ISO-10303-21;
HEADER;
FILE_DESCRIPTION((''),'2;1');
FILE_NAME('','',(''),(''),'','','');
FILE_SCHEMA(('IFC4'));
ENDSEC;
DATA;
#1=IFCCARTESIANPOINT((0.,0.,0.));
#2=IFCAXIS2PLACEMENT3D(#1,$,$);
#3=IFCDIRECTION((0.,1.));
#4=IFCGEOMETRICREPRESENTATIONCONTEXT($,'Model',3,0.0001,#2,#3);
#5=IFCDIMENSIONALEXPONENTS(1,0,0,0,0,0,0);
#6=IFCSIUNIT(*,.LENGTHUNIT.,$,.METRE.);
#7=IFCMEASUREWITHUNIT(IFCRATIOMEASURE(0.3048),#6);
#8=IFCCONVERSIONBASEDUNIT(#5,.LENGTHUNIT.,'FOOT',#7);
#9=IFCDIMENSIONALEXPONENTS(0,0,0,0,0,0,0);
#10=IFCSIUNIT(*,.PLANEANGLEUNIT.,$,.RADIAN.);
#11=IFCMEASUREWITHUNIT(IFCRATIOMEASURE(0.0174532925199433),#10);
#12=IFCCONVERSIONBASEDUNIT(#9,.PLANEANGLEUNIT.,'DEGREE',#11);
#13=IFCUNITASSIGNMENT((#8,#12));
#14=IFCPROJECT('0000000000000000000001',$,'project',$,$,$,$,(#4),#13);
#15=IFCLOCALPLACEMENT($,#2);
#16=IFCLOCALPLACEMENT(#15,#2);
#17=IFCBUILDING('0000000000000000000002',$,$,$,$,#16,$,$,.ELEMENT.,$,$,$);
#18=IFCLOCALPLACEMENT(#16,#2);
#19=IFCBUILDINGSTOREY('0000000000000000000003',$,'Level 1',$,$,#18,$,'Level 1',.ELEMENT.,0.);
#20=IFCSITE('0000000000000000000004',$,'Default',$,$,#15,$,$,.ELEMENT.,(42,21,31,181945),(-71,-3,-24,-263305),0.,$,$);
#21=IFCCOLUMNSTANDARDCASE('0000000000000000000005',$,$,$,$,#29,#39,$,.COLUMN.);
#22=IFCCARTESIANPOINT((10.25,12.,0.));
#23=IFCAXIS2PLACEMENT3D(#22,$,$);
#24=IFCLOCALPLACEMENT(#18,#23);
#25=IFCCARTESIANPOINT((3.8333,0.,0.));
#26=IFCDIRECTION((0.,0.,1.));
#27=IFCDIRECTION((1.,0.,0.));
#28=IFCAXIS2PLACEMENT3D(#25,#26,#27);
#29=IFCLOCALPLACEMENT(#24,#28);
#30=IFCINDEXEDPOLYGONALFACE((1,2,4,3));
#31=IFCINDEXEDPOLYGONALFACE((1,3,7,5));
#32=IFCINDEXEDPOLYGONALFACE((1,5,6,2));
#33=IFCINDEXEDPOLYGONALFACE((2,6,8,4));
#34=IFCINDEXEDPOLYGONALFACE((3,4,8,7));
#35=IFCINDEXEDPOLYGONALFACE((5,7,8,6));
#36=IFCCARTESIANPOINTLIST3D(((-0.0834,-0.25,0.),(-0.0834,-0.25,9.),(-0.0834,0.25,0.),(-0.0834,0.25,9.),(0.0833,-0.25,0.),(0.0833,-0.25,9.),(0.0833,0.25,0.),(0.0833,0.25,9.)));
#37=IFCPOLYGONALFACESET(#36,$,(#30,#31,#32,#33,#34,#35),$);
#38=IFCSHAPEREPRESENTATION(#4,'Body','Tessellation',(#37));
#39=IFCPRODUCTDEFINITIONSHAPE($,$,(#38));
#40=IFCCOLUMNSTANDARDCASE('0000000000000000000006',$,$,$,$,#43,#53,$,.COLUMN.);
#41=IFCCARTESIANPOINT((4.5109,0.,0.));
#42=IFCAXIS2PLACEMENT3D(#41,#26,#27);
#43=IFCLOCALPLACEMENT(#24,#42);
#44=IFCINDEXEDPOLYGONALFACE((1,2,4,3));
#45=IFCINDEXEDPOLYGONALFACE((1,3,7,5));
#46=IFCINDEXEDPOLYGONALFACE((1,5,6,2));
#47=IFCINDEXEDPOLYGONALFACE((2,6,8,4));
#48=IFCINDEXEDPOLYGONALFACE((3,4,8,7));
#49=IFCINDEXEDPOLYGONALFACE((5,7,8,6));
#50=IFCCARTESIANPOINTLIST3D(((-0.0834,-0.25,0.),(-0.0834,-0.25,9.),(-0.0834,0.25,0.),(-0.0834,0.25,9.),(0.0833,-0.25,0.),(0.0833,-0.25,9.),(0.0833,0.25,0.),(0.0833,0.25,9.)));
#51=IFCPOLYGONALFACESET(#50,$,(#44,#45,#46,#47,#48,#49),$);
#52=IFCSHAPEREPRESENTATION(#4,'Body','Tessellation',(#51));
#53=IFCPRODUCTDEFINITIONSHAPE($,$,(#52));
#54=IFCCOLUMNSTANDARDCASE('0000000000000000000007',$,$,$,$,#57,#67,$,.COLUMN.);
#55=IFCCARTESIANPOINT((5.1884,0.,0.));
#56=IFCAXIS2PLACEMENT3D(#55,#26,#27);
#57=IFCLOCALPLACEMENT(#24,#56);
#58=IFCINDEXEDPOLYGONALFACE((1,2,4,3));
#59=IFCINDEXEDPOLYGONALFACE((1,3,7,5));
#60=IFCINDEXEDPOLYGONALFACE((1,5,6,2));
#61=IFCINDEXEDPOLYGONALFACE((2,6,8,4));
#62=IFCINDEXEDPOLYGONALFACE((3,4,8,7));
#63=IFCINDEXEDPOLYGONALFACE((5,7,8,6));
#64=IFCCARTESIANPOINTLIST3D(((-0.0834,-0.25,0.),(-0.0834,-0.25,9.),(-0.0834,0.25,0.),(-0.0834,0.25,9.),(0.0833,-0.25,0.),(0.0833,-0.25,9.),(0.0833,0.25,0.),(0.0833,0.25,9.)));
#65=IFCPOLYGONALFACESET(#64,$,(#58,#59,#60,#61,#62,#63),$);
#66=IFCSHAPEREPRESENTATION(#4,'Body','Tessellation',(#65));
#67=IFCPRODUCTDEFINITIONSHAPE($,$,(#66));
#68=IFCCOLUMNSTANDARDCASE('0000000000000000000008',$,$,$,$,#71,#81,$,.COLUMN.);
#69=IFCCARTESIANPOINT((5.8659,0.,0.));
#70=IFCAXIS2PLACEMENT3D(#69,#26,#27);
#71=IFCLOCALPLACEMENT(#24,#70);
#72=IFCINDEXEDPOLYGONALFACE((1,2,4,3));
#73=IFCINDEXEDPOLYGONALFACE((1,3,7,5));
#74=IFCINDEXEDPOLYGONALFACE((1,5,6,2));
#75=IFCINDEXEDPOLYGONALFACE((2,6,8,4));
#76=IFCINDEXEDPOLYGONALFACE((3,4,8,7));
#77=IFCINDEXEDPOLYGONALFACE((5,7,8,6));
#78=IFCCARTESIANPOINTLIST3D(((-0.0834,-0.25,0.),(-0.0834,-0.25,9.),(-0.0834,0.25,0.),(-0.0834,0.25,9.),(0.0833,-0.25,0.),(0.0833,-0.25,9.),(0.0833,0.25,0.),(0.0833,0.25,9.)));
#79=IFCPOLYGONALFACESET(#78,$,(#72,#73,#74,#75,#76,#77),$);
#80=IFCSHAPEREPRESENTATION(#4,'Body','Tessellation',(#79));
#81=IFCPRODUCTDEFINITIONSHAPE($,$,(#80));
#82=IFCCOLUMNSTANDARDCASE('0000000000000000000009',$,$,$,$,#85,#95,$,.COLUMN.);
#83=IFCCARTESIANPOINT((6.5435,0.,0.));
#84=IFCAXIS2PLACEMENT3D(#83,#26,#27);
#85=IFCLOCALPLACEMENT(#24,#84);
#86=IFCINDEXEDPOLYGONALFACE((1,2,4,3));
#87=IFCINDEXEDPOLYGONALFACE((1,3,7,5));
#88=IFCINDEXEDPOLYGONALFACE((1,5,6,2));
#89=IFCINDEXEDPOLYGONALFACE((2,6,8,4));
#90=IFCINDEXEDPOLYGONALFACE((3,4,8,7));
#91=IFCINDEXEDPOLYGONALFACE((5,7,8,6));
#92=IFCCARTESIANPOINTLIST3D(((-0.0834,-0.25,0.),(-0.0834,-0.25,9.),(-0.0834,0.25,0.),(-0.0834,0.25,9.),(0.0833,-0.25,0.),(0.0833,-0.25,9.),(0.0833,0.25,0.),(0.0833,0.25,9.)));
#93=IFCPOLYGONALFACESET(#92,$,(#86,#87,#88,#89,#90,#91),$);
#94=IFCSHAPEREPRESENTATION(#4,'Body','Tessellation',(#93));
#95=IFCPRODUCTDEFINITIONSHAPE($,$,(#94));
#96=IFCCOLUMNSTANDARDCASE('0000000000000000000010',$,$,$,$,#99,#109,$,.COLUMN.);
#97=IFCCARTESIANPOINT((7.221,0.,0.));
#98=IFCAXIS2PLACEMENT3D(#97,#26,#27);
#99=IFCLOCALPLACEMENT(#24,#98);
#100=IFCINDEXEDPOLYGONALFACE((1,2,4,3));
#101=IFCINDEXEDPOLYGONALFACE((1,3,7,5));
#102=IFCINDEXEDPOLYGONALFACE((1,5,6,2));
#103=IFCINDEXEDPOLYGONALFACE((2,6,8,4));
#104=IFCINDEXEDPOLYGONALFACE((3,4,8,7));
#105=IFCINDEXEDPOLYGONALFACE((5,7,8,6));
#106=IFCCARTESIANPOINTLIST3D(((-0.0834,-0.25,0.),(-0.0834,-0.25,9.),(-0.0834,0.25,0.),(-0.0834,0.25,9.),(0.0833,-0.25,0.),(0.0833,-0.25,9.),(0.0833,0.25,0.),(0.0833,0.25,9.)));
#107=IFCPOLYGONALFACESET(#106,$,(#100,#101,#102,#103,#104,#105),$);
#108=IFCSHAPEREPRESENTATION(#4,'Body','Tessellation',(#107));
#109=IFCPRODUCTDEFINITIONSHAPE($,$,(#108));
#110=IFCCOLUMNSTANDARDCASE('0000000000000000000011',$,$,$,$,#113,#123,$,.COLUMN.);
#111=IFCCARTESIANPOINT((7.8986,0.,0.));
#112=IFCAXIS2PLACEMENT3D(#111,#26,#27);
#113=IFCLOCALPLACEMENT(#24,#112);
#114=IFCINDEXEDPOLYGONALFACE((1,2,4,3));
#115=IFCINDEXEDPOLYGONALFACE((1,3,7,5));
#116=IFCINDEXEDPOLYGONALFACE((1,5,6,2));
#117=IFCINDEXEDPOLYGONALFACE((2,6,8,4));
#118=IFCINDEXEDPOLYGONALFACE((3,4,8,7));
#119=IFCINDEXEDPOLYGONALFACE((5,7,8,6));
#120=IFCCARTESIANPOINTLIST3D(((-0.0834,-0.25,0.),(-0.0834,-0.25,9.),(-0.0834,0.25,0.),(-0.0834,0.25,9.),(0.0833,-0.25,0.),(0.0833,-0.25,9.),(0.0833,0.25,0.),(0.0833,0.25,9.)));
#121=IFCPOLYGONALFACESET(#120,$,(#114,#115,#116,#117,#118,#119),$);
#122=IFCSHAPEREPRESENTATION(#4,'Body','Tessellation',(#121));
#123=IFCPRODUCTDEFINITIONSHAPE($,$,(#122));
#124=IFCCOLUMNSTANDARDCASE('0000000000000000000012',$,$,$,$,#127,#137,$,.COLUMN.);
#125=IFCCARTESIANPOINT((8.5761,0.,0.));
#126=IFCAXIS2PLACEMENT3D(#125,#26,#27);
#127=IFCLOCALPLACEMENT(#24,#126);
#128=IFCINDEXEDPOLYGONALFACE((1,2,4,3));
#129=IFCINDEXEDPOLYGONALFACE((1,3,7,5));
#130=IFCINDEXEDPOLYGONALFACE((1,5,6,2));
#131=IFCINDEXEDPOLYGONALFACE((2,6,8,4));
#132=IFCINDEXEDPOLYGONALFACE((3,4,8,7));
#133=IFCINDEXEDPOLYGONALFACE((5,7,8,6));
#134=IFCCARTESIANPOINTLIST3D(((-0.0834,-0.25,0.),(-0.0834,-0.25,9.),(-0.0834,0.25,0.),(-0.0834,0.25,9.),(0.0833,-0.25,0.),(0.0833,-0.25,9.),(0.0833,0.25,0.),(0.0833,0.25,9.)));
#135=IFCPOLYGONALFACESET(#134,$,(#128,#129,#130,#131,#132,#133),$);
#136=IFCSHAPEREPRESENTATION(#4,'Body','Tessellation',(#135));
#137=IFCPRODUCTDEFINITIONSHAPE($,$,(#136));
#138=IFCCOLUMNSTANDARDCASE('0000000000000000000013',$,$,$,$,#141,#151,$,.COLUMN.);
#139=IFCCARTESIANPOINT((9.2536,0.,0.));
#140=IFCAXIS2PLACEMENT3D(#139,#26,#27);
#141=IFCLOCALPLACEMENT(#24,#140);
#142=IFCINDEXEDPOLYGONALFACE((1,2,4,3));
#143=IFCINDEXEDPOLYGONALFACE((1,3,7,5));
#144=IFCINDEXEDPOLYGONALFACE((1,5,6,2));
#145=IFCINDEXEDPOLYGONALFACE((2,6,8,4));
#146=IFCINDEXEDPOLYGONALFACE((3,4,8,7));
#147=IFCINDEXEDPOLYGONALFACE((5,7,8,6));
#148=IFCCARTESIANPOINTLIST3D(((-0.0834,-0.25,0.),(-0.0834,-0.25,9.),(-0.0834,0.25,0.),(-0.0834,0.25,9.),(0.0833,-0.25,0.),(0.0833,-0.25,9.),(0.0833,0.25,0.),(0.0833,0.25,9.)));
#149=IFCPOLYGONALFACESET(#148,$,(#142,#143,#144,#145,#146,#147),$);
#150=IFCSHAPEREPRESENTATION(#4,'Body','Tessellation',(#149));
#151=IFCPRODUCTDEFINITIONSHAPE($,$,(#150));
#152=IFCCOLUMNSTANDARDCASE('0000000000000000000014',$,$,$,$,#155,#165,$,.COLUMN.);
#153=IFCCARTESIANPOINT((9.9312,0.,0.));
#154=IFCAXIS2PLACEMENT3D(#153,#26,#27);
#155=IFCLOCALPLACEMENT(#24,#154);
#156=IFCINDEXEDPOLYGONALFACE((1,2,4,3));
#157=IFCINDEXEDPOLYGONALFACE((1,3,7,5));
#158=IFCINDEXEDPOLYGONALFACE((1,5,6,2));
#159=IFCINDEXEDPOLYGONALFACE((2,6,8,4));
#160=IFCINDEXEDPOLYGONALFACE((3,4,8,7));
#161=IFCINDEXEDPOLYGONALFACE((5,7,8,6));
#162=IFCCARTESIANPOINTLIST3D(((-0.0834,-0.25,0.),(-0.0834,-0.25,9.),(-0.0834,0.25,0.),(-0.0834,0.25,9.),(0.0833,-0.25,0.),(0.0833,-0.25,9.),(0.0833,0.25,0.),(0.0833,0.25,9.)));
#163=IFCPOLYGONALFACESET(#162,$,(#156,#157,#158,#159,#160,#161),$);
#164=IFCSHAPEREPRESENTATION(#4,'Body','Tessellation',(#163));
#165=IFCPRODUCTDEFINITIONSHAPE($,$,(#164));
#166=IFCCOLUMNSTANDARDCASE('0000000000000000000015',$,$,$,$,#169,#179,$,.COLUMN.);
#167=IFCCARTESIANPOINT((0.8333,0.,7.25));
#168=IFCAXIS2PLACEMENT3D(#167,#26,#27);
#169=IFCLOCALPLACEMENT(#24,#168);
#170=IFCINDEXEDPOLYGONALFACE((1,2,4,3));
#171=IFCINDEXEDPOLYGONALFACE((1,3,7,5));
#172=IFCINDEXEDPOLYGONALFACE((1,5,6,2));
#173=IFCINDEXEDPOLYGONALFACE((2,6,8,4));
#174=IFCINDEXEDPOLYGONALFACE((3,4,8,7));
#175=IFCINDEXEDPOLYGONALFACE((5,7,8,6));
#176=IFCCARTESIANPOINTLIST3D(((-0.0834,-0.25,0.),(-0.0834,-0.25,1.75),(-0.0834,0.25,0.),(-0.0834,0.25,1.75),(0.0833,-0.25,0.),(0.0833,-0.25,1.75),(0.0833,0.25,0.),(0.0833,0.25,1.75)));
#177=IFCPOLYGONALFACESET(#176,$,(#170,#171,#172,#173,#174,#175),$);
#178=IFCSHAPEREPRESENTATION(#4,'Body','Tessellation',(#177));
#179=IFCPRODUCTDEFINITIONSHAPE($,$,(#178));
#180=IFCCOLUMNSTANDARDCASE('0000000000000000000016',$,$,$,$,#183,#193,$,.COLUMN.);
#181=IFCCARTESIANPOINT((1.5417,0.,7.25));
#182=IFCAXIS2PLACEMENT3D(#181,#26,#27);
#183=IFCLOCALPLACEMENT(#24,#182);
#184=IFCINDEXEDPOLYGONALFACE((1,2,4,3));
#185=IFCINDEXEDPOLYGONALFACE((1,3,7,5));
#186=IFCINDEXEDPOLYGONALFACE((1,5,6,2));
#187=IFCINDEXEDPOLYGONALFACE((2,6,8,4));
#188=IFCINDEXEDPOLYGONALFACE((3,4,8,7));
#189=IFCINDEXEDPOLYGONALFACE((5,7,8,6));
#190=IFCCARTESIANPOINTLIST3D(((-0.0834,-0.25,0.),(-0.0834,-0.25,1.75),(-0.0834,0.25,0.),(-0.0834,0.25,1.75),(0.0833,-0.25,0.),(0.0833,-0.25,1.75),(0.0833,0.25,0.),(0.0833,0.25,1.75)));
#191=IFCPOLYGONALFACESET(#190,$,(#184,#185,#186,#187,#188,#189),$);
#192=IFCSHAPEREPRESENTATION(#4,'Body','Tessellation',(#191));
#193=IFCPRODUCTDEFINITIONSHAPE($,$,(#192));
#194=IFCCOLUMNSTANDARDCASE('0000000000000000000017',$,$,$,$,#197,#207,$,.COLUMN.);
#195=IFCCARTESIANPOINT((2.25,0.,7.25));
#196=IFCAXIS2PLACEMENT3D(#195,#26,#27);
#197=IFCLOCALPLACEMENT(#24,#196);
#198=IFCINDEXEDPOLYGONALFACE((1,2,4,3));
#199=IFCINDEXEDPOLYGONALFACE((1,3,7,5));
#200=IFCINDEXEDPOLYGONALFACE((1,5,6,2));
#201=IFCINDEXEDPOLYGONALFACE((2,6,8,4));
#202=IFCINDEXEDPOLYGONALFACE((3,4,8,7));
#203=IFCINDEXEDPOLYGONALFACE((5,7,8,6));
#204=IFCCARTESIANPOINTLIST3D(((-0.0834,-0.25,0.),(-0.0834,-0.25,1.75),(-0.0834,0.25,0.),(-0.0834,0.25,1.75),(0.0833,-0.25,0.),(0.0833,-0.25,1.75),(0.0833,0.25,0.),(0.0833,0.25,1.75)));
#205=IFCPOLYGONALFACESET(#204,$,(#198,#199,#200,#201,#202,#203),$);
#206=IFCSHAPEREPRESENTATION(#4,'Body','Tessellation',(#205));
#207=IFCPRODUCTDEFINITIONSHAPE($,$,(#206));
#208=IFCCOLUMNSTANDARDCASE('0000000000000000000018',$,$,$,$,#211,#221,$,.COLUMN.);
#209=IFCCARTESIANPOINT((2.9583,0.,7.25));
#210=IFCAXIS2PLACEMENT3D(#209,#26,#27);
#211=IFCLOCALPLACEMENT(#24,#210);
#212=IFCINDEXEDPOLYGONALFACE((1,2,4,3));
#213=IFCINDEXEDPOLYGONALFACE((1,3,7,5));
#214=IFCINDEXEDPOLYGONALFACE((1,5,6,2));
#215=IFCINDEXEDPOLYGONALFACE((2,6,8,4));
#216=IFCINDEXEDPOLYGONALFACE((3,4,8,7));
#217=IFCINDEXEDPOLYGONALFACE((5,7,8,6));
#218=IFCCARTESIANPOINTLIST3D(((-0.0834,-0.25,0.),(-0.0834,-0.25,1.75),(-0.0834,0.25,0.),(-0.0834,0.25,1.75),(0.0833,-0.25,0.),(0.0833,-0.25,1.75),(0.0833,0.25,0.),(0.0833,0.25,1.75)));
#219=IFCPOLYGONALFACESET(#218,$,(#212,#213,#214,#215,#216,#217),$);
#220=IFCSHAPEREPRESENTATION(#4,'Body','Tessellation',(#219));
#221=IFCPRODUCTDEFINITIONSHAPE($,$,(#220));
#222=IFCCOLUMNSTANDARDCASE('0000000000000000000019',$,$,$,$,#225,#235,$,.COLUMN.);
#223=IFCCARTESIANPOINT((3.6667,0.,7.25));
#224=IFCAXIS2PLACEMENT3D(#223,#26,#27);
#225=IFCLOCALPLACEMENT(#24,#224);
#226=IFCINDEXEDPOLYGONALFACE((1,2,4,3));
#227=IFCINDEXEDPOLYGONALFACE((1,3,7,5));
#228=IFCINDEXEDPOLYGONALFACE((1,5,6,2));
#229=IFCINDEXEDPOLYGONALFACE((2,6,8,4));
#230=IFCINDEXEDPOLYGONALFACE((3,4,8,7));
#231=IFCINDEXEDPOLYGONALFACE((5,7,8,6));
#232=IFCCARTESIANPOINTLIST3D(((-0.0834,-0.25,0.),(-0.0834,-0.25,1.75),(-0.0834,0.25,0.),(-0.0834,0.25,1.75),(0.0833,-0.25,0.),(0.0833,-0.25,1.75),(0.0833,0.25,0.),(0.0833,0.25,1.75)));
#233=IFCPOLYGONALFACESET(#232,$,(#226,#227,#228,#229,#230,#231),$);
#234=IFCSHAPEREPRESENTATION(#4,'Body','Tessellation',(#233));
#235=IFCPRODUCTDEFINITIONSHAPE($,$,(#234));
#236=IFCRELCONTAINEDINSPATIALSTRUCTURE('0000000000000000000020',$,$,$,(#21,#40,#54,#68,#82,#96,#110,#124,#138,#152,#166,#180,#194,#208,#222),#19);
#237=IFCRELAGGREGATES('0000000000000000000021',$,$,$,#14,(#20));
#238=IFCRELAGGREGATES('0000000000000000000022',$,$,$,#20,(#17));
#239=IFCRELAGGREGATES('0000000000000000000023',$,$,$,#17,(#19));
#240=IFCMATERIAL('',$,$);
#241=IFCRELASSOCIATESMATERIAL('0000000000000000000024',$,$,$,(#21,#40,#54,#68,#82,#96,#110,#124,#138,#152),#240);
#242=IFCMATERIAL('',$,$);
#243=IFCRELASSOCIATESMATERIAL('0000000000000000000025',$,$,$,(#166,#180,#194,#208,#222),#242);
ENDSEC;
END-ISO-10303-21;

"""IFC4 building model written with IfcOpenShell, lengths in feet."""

from ifc_helpers import new_model, entity, si_unit, converted_unit, direction, frame, origin, place, context, project, spatial, rectangle, extrude, material, element, save


model = new_model("IFC4")

# Units and contexts
model_context = context("Model", 3, precision=0.0001, world=origin(), true_north=direction((0.0, 1.0)))
ifc_project = project(units=[converted_unit("LENGTHUNIT", "FOOT", entity("IfcRatioMeasure", 0.3048), si_unit("LENGTHUNIT", "METRE"), dimensions=[1, 0, 0, 0, 0, 0, 0]), converted_unit("PLANEANGLEUNIT", "DEGREE", entity("IfcRatioMeasure", 0.0174532925199433), si_unit("PLANEANGLEUNIT", "RADIAN"), dimensions=[0, 0, 0, 0, 0, 0, 0])], contexts=[model_context])

# Site, building, storey
site_placement = place(None, origin())
site = spatial("IfcSite", under=ifc_project, at=site_placement, Name="Default", CompositionType="ELEMENT", RefLatitude=(42, 21, 31, 181945), RefLongitude=(-71, -3, -24, -263305), RefElevation=0.0)
building_placement = place(site_placement, origin())
building = spatial("IfcBuilding", under=site, at=building_placement, CompositionType="ELEMENT")
storey_placement = place(building_placement, origin())
storey = spatial("IfcBuildingStorey", under=building, at=storey_placement, Name="Level 1", LongName="Level 1", CompositionType="ELEMENT", Elevation=0.0)

# Columns
ifc_material_1 = material(Name="")
placement_1 = place(storey_placement, frame((10.25, 12.0, 0.0)))
for number, where, z_axis, x_axis in (
    (1, (3.8333, 0.0, 0.0), (0.0, 0.0, 1.0), (1.0, 0.0, 0.0)),
    (2, (4.5109, 0.0, 0.0), (0.0, 0.0, 1.0), (1.0, 0.0, 0.0)),
    (3, (5.1884, 0.0, 0.0), (0.0, 0.0, 1.0), (1.0, 0.0, 0.0)),
    (4, (5.8659, 0.0, 0.0), (0.0, 0.0, 1.0), (1.0, 0.0, 0.0)),
    (5, (6.5435, 0.0, 0.0), (0.0, 0.0, 1.0), (1.0, 0.0, 0.0)),
    (6, (7.221, 0.0, 0.0), (0.0, 0.0, 1.0), (1.0, 0.0, 0.0)),
    (7, (7.8986, 0.0, 0.0), (0.0, 0.0, 1.0), (1.0, 0.0, 0.0)),
    (8, (8.5761, 0.0, 0.0), (0.0, 0.0, 1.0), (1.0, 0.0, 0.0)),
    (9, (9.2536, 0.0, 0.0), (0.0, 0.0, 1.0), (1.0, 0.0, 0.0)),
    (10, (9.9312, 0.0, 0.0), (0.0, 0.0, 1.0), (1.0, 0.0, 0.0)),
):
    element("IfcColumnStandardCase", number, at=place(placement_1, frame(where, z_axis=z_axis, x_axis=x_axis)), inside=storey, material=ifc_material_1, PredefinedType="COLUMN", context=model_context, shape_type="SweptSolid", body=[
        extrude(rectangle(XDim=0.1667, YDim=0.5), origin(), (0.0, 0.0, 1.0), 9.0),
    ])
ifc_material_2 = material(Name="")
for number, where, z_axis, x_axis in (
    (11, (0.8333, 0.0, 7.25), (0.0, 0.0, 1.0), (1.0, 0.0, 0.0)),
    (12, (1.5417, 0.0, 7.25), (0.0, 0.0, 1.0), (1.0, 0.0, 0.0)),
    (13, (2.25, 0.0, 7.25), (0.0, 0.0, 1.0), (1.0, 0.0, 0.0)),
    (14, (2.9583, 0.0, 7.25), (0.0, 0.0, 1.0), (1.0, 0.0, 0.0)),
    (15, (3.6667, 0.0, 7.25), (0.0, 0.0, 1.0), (1.0, 0.0, 0.0)),
):
    element("IfcColumnStandardCase", number, at=place(placement_1, frame(where, z_axis=z_axis, x_axis=x_axis)), inside=storey, material=ifc_material_2, PredefinedType="COLUMN", context=model_context, shape_type="SweptSolid", body=[
        extrude(rectangle(XDim=0.1667, YDim=0.5), origin(), (0.0, 0.0, 1.0), 1.75),
    ])

save(model, "model.ifc")
